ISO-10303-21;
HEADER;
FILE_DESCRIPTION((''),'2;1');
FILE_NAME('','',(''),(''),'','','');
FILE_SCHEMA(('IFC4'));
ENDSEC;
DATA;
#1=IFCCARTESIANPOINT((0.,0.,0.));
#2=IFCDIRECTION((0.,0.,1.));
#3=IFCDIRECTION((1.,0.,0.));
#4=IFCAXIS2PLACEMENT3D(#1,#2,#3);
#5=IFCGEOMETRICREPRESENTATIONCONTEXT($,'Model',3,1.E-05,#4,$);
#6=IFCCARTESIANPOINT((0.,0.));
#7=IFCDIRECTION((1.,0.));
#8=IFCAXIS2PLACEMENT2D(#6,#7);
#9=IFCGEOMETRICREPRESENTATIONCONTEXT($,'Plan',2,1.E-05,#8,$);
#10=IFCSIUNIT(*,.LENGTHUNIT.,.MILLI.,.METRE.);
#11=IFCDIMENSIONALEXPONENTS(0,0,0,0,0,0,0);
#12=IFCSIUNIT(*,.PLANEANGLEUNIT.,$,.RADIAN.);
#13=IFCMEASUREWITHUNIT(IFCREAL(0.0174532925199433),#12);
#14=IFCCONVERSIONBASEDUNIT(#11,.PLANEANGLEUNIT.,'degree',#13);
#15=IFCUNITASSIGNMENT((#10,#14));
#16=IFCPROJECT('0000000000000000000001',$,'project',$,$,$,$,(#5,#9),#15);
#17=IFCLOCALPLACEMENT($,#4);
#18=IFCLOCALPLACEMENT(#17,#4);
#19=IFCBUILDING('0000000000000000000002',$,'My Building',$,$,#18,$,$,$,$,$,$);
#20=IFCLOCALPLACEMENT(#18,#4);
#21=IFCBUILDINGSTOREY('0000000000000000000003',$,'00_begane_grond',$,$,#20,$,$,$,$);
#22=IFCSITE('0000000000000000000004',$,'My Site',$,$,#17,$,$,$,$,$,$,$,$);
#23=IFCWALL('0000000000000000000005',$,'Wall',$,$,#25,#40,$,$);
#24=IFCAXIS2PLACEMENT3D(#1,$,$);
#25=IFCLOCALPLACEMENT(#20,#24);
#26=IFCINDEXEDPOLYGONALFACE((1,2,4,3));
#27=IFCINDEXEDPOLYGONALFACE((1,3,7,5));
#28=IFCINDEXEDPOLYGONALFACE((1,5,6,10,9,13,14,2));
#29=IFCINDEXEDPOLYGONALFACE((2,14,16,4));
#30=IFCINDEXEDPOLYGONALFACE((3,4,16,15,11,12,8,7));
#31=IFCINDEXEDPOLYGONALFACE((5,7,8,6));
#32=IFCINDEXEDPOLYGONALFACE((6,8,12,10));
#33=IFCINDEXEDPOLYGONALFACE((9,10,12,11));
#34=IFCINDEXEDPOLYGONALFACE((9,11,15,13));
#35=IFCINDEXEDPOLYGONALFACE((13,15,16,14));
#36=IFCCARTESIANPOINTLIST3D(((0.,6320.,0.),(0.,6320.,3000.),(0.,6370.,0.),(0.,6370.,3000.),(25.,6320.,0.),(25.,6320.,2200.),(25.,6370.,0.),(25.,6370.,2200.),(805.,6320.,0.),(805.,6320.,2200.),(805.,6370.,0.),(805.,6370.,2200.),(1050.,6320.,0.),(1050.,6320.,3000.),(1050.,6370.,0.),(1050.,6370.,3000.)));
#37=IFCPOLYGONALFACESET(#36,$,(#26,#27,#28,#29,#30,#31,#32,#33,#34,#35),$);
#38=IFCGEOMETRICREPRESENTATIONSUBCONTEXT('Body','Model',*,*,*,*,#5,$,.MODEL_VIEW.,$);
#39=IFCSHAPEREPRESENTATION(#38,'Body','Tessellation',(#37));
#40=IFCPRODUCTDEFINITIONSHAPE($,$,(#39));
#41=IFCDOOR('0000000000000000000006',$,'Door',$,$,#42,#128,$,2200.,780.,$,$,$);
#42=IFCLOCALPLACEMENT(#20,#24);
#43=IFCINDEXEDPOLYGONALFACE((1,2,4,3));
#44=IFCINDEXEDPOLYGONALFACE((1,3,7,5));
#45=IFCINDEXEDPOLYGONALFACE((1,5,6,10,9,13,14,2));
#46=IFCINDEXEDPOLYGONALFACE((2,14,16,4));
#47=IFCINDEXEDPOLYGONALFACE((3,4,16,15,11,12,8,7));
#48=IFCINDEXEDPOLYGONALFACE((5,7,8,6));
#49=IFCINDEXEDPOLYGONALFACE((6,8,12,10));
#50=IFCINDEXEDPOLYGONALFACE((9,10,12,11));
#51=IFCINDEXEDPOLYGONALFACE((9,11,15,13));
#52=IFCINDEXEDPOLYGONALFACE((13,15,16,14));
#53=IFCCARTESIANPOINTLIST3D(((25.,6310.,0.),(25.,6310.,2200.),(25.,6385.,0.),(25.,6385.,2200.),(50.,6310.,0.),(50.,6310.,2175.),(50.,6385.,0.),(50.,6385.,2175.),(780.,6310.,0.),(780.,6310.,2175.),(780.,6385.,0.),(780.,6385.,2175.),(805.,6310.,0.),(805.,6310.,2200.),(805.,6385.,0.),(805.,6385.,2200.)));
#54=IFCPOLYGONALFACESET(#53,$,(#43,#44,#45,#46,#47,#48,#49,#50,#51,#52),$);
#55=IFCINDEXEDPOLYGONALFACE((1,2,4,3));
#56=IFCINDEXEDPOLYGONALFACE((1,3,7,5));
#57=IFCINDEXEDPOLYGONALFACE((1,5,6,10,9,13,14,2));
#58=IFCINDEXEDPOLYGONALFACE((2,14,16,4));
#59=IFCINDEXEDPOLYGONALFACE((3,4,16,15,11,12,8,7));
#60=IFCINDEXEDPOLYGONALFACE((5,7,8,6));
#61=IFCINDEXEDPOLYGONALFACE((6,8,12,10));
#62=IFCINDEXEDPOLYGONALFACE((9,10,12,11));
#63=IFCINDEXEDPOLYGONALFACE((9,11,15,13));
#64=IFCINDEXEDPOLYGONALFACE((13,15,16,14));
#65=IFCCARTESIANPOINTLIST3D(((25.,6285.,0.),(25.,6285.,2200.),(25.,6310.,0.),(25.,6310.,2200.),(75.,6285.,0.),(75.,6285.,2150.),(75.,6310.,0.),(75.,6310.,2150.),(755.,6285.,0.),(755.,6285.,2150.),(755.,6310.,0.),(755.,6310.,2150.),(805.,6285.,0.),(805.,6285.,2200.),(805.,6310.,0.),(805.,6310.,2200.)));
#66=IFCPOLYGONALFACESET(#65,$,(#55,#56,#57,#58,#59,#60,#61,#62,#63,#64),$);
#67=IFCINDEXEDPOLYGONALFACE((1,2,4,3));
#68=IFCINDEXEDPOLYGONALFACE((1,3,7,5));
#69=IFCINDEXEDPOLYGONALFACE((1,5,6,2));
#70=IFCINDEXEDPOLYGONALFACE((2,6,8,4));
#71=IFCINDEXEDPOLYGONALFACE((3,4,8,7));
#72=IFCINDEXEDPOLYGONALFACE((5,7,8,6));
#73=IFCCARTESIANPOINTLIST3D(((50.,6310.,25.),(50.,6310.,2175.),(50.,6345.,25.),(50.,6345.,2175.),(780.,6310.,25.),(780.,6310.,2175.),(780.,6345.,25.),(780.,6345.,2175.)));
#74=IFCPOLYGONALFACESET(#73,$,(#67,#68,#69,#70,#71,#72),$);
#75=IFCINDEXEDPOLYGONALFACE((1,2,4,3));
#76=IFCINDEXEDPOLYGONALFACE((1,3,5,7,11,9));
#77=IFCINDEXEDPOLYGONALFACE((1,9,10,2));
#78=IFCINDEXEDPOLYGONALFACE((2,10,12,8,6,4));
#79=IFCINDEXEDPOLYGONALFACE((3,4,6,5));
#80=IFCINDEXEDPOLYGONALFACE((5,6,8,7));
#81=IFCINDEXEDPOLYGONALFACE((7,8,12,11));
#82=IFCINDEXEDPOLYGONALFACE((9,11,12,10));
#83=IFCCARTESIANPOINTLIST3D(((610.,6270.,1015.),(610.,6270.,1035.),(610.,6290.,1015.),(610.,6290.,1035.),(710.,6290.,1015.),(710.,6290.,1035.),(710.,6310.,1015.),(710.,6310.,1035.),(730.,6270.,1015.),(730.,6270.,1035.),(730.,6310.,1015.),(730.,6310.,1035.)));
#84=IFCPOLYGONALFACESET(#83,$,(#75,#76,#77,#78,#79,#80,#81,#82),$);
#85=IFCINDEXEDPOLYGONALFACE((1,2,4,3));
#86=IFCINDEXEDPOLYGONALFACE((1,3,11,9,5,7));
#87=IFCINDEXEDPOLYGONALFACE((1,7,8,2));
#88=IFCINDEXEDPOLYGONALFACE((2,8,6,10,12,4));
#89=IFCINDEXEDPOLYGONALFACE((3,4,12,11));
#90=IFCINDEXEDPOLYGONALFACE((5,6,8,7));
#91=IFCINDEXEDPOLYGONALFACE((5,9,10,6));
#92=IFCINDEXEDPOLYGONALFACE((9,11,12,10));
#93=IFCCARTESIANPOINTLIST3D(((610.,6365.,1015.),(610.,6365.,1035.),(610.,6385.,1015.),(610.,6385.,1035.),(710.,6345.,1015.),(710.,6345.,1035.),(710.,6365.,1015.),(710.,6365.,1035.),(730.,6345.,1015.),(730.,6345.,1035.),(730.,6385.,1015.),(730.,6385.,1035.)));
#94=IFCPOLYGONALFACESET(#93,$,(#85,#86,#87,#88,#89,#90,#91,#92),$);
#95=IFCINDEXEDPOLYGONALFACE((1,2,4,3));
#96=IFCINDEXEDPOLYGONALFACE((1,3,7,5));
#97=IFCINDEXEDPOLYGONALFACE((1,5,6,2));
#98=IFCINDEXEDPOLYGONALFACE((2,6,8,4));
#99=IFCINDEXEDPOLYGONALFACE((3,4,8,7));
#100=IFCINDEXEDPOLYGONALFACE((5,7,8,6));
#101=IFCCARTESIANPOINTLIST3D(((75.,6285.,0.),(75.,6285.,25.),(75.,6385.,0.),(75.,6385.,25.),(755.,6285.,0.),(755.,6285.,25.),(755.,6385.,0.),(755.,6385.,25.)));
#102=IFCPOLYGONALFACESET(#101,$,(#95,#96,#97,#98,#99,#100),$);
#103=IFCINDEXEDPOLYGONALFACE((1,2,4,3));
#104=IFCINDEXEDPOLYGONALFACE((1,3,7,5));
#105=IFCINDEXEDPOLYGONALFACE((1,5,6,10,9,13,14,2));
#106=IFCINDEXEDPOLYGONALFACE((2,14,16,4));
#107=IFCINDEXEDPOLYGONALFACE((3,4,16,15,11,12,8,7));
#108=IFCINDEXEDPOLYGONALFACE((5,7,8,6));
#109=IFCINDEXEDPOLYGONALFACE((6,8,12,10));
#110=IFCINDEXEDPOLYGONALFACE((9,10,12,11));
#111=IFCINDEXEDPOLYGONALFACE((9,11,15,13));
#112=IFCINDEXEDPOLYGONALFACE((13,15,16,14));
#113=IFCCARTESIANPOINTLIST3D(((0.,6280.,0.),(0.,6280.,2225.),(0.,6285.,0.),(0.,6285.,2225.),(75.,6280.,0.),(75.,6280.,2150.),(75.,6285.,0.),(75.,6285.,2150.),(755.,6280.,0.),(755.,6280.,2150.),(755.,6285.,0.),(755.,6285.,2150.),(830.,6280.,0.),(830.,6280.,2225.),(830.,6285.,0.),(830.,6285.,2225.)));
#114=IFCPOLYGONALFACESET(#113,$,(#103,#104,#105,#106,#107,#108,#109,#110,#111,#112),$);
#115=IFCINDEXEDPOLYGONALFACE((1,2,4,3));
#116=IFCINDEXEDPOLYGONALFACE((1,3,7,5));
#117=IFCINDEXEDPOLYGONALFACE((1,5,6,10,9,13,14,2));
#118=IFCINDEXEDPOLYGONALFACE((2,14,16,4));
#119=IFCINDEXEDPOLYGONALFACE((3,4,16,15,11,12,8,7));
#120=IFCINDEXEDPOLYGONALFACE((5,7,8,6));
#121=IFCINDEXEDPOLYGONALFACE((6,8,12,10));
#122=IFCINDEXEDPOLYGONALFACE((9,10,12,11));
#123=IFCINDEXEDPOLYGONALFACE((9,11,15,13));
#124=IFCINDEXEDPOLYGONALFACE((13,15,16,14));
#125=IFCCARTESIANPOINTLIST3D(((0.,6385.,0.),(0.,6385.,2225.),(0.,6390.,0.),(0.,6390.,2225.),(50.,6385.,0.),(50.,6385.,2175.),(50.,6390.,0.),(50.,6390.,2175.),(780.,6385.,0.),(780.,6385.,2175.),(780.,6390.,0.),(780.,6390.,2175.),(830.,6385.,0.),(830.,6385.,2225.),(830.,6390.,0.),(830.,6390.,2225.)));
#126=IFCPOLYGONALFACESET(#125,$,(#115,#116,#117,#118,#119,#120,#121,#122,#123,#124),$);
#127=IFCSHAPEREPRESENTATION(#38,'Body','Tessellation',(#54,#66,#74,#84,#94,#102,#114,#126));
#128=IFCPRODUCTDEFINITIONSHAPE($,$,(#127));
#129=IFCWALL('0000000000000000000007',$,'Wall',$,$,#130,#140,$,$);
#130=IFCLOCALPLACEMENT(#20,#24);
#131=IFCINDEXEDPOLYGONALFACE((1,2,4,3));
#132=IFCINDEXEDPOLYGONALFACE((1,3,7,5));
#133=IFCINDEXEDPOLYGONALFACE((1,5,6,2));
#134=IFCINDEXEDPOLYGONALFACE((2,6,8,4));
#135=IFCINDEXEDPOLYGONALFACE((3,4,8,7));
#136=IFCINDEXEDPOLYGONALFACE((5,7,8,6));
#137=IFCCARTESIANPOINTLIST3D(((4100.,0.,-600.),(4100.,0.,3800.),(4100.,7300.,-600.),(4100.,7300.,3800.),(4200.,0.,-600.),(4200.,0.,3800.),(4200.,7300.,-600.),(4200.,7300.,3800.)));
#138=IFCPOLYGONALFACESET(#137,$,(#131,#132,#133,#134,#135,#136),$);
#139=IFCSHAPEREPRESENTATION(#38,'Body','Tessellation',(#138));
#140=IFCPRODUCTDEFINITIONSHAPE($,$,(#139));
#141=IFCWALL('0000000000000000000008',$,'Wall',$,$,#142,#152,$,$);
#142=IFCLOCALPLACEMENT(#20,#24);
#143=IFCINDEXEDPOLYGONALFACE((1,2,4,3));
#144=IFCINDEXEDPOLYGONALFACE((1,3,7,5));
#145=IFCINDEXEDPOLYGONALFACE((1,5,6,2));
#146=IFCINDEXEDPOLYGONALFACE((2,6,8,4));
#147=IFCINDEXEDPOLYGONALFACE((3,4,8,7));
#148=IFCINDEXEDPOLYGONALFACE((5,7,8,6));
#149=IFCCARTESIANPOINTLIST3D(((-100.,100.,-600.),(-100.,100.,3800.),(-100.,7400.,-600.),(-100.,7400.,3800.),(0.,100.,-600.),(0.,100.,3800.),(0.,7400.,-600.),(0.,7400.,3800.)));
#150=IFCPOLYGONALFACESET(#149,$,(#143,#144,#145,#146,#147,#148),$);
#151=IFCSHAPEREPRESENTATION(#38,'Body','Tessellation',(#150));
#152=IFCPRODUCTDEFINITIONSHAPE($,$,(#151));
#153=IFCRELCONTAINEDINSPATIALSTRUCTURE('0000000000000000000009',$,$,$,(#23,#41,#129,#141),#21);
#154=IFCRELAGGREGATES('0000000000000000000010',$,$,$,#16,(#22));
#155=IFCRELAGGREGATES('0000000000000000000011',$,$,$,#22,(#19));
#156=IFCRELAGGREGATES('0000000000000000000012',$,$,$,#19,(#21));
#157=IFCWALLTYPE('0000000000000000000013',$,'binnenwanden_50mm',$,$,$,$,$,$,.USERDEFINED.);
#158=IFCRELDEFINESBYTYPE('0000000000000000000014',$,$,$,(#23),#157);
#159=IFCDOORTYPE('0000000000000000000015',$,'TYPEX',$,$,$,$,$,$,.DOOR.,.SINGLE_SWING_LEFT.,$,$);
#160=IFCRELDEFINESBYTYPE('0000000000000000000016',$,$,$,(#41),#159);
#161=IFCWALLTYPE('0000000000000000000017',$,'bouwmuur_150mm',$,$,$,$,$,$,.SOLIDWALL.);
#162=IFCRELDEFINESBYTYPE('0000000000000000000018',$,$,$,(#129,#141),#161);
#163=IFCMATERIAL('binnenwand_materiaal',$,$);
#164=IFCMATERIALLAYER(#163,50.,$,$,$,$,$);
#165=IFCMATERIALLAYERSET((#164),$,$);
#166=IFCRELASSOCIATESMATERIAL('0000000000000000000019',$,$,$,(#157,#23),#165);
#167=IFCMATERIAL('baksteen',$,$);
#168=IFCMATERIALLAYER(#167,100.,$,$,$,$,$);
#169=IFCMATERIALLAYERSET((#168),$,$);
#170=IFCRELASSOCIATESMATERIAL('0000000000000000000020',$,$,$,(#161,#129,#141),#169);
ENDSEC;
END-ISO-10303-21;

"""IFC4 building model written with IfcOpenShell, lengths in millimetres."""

from ifc_helpers import new_model, entity, si_unit, converted_unit, frame, origin_with_axes, origin_2d_with_axis, place, context, subcontext, project, spatial, line, indexed_curve, outline, extrude, shape, source, transform, mapped, material, layer, layer_set, layer_usage, type_object, type_shapes, element, fill, save


model = new_model("IFC4")

# Units and contexts
model_context = context("Model", 3, precision=1e-05, world=origin_with_axes())
plan_context = context("Plan", 2, precision=1e-05, world=origin_2d_with_axis())
body_context_1 = subcontext(model_context, "Body", "Model", "MODEL_VIEW")
body_context_2 = subcontext(plan_context, "Body", "Plan", "PLAN_VIEW")
ifc_project = project(units=[si_unit("LENGTHUNIT", "METRE", prefix="MILLI"), converted_unit("PLANEANGLEUNIT", "degree", entity("IfcReal", 0.0174532925199433), si_unit("PLANEANGLEUNIT", "RADIAN"), dimensions=[0, 0, 0, 0, 0, 0, 0])], contexts=[model_context, plan_context])

# Site, building, storey
site_placement = place(None, origin_with_axes())
site = spatial("IfcSite", under=ifc_project, at=site_placement, Name="My Site")
building_placement = place(site_placement, origin_with_axes())
building = spatial("IfcBuilding", under=site, at=building_placement, Name="My Building")
storey_placement = place(building_placement, origin_with_axes())
storey = spatial("IfcBuildingStorey", under=building, at=storey_placement, Name="00_begane_grond")

# Shared definitions
ifc_material_1 = material(Name="baksteen")

# Shared definitions
shared_shape_1 = source(origin_with_axes(), body_context_1, "Body", "SweptSolid", [
    extrude(outline(indexed_curve([(0.0, 0.0), (780.0, 0.0), (780.0, 2200.0), (0.0, 2200.0)], segments=[line(1, 2, 3, 4, 1)])), frame((0.0, -100.0, 0.0), z_axis=(0.0, -1.0, 0.0), x_axis=(1.0, 0.0, 0.0)), (0.0, 0.0, -1.0), 300.0),
])
door_type = type_object("IfcDoorType", Name="TYPEX", OperationType="SINGLE_SWING_LEFT", PredefinedType="DOOR")
shared_shape_2 = source(origin_with_axes(), body_context_1, "Body", "SweptSolid", [
    extrude(outline(indexed_curve([(0.0, 0.0), (0.0, 2200.0), (780.0, 2200.0), (780.0, 0.0), (755.0, 0.0), (755.0, 2175.0), (25.0, 2175.0), (25.0, 0.0)], segments=[line(1, 2, 3, 4, 5, 6, 7, 8, 1)])), frame((0.0, 25.0, 0.0), z_axis=(0.0, -1.0, 0.0), x_axis=(1.0, 0.0, 0.0)), (0.0, 0.0, -1.0), 75.0),
    extrude(outline(indexed_curve([(0.0, 0.0), (0.0, 2200.0), (780.0, 2200.0), (780.0, 0.0), (730.0, 0.0), (730.0, 2150.0), (50.0, 2150.0), (50.0, 0.0)], segments=[line(1, 2, 3, 4, 5, 6, 7, 8, 1)])), frame((0.0, 0.0, 0.0), z_axis=(0.0, -1.0, 0.0), x_axis=(1.0, 0.0, 0.0)), (0.0, 0.0, -1.0), 25.0),
    extrude(outline(indexed_curve([(0.0, 0.0), (730.0, 0.0), (730.0, 35.0), (0.0, 35.0)], segments=[line(1, 2, 3, 4, 1)])), frame((25.0, 25.0, 25.0), z_axis=(0.0, 0.0, 1.0), x_axis=(1.0, 0.0, 0.0)), (0.0, 0.0, 1.0), 2150.0),
    extrude(outline(indexed_curve([(0.0, 0.0), (0.0, -40.0), (-120.0, -40.0), (-120.0, -20.0), (-20.0, -20.0), (-20.0, 0.0)], segments=[line(1, 2, 3, 4, 5, 6, 1)])), frame((705.0, 25.0, 1015.0), z_axis=(0.0, 0.0, 1.0), x_axis=(1.0, 0.0, 0.0)), (0.0, 0.0, 1.0), 20.0),
    extrude(outline(indexed_curve([(0.0, 0.0), (0.0, 40.0), (-120.0, 40.0), (-120.0, 20.0), (-20.0, 20.0), (-20.0, 0.0)], segments=[line(1, 2, 3, 4, 5, 6, 1)])), frame((705.0, 60.0, 1015.0), z_axis=(0.0, 0.0, 1.0), x_axis=(1.0, 0.0, 0.0)), (0.0, 0.0, 1.0), 20.0),
    extrude(outline(indexed_curve([(0.0, 0.0), (680.0, 0.0), (680.0, 100.0), (0.0, 100.0)], segments=[line(1, 2, 3, 4, 1)])), frame((50.0, 0.0, 0.0), z_axis=(0.0, 0.0, 1.0), x_axis=(1.0, 0.0, 0.0)), (0.0, 0.0, 1.0), 25.0),
    extrude(outline(indexed_curve([(0.0, 0.0), (0.0, 2225.0), (830.0, 2225.0), (830.0, 0.0), (755.0, 0.0), (755.0, 2150.0), (75.0, 2150.0), (75.0, 0.0)], segments=[line(1, 2, 3, 4, 5, 6, 7, 8, 1)])), frame((-25.0, -5.0, 0.0), z_axis=(0.0, -1.0, 0.0), x_axis=(1.0, 0.0, 0.0)), (0.0, 0.0, -1.0), 5.0),
    extrude(outline(indexed_curve([(0.0, 0.0), (0.0, 2225.0), (830.0, 2225.0), (830.0, 0.0), (780.0, 0.0), (780.0, 2175.0), (50.0, 2175.0), (50.0, 0.0)], segments=[line(1, 2, 3, 4, 5, 6, 7, 8, 1)])), frame((-25.0, 100.0, 0.0), z_axis=(0.0, -1.0, 0.0), x_axis=(1.0, 0.0, 0.0)), (0.0, 0.0, -1.0), 5.0),
])
shared_shape_3 = source(origin_with_axes(), body_context_2, "Body", "Curve2D", [
    entity("IfcIndexedPolyCurve", entity("IfcCartesianPointList2D", [[0.0, 0.0], [0.0, 100.0], [25.0, 100.0], [25.0, 25.0], [50.0, 25.0], [50.0, 0.0]]), [entity("IfcLineIndex", [1, 2, 3, 4, 5, 6, 1])]),
    entity("IfcIndexedPolyCurve", entity("IfcCartesianPointList2D", [[780.0, 0.0], [780.0, 100.0], [755.0, 100.0], [755.0, 25.0], [730.0, 25.0], [730.0, 0.0]]), [entity("IfcLineIndex", [1, 2, 3, 4, 5, 6, 1])]),
    entity("IfcTrimmedCurve", entity("IfcEllipse", entity("IfcAxis2Placement2D", entity("IfcCartesianPoint", [60.0, 100.0]), entity("IfcDirection", [1.0, 0.0])), 695.0, 730.0), [entity("IfcCartesianPoint", [755.0, 100.0])], [entity("IfcCartesianPoint", [60.0, 830.0])], True, "CARTESIAN"),
    entity("IfcIndexedPolyCurve", entity("IfcCartesianPointList2D", [[25.0, 100.0], [60.0, 100.0], [60.0, 830.0], [25.0, 830.0]]), [entity("IfcLineIndex", [1, 2, 3, 4, 1])]),
])
type_shapes(door_type, [shared_shape_2, shared_shape_3])

# Shared definitions
ifc_material_2 = material(Name="binnenwand_materiaal")
ifc_layer_1 = layer(ifc_material_2, 50.0)
ifc_layer_set_1 = layer_set([ifc_layer_1])
wall_type_1 = type_object("IfcWallType", Name="binnenwanden_50mm", PredefinedType="USERDEFINED", material=ifc_layer_set_1)

# Wall, opening, door
ifc_layer_usage_1 = layer_usage(ifc_layer_set_1, "AXIS2", "POSITIVE", 0.0)
wall_1_placement = place(storey_placement, frame((1050.0, 6370.0, 0.0), z_axis=(0.0, 0.0, 1.0), x_axis=(-1.0, 0.0, 0.0)))
wall_1 = element("IfcWall", 1, at=wall_1_placement, inside=storey, type_object=wall_type_1, material=ifc_layer_usage_1, Name="Wall", context=body_context_1, shape_type="SweptSolid", body=[
    extrude(outline(indexed_curve([(0.0, 0.0), (0.0, 50.0), (1050.0, 50.0), (1050.0, 0.0), (0.0, 0.0)], self_intersect=False)), origin_with_axes(), (0.0, 0.0, 1.0), 3000.0),
])
opening_1_placement = place(wall_1_placement, frame((1025.0, 85.0, 0.0), z_axis=(0.0, 0.0, 1.0), x_axis=(-1.0, 0.0, 0.0)))
opening_1 = element("IfcOpeningElement", 2, at=opening_1_placement, cuts=wall_1, PredefinedType="OPENING", context=body_context_1, shape_type="MappedRepresentation", body=[
    mapped(shared_shape_1, transform((0.0, 0.0, 0.0), x_axis=(1.0, 0.0, 0.0), y_axis=(0.0, 1.0, 0.0), z_axis=(0.0, 0.0, 1.0), scale=1.0)),
])
door_1_placement = place(opening_1_placement, frame((0.0, 0.0, 0.0), z_axis=(0.0, 0.0, 1.0), x_axis=(1.0, 0.0, 0.0)))
door_1 = element("IfcDoor", 3, at=door_1_placement, inside=storey, type_object=door_type, Name="Door", OverallHeight=2200.0, OverallWidth=780.0, shapes=[
    shape(body_context_1, "Body", "MappedRepresentation", [mapped(shared_shape_2, transform((0.0, 0.0, 0.0), x_axis=(1.0, 0.0, 0.0), y_axis=(0.0, 1.0, 0.0), z_axis=(0.0, 0.0, 1.0), scale=1.0))]),
    shape(body_context_2, "Body", "MappedRepresentation", [mapped(shared_shape_3, transform((0.0, 0.0, 0.0), x_axis=(1.0, 0.0, 0.0), y_axis=(0.0, 1.0, 0.0), z_axis=(0.0, 0.0, 1.0), scale=1.0))]),
])
fill(opening_1, door_1)

# Walls
ifc_layer_2 = layer(ifc_material_1, 100.0)
ifc_layer_set_2 = layer_set([ifc_layer_2])
ifc_layer_usage_2 = layer_usage(ifc_layer_set_2, "AXIS2", "POSITIVE", 0.0)
wall_type_2 = type_object("IfcWallType", Name="bouwmuur_150mm", PredefinedType="SOLIDWALL", material=ifc_layer_set_2)
wall_2_placement = place(storey_placement, frame((4200.0, 0.0, -600.0), z_axis=(0.0, 0.0, 1.0), x_axis=(0.0, 1.0, 0.0)))
element("IfcWall", 4, at=wall_2_placement, inside=storey, type_object=wall_type_2, material=ifc_layer_usage_2, Name="Wall", context=body_context_1, shape_type="SweptSolid", body=[
    extrude(outline(indexed_curve([(0.0, 0.0), (0.0, 100.0), (7300.0, 100.0), (7300.0, 0.0), (0.0, 0.0)], self_intersect=False)), origin_with_axes(), (0.0, 0.0, 1.0), 4400.0),
])
ifc_layer_usage_3 = layer_usage(ifc_layer_set_2, "AXIS2", "POSITIVE", 0.0)
wall_3_placement = place(storey_placement, frame((0.0, 100.0, -600.0), z_axis=(0.0, 0.0, 1.0), x_axis=(0.0, 1.0, 0.0)))
element("IfcWall", 5, at=wall_3_placement, inside=storey, type_object=wall_type_2, material=ifc_layer_usage_3, Name="Wall", context=body_context_1, shape_type="SweptSolid", body=[
    extrude(outline(indexed_curve([(0.0, 0.0), (0.0, 100.0), (7300.0, 100.0), (7300.0, 0.0), (0.0, 0.0)], self_intersect=False)), origin_with_axes(), (0.0, 0.0, 1.0), 4400.0),
])

save(model, "model.ifc")
